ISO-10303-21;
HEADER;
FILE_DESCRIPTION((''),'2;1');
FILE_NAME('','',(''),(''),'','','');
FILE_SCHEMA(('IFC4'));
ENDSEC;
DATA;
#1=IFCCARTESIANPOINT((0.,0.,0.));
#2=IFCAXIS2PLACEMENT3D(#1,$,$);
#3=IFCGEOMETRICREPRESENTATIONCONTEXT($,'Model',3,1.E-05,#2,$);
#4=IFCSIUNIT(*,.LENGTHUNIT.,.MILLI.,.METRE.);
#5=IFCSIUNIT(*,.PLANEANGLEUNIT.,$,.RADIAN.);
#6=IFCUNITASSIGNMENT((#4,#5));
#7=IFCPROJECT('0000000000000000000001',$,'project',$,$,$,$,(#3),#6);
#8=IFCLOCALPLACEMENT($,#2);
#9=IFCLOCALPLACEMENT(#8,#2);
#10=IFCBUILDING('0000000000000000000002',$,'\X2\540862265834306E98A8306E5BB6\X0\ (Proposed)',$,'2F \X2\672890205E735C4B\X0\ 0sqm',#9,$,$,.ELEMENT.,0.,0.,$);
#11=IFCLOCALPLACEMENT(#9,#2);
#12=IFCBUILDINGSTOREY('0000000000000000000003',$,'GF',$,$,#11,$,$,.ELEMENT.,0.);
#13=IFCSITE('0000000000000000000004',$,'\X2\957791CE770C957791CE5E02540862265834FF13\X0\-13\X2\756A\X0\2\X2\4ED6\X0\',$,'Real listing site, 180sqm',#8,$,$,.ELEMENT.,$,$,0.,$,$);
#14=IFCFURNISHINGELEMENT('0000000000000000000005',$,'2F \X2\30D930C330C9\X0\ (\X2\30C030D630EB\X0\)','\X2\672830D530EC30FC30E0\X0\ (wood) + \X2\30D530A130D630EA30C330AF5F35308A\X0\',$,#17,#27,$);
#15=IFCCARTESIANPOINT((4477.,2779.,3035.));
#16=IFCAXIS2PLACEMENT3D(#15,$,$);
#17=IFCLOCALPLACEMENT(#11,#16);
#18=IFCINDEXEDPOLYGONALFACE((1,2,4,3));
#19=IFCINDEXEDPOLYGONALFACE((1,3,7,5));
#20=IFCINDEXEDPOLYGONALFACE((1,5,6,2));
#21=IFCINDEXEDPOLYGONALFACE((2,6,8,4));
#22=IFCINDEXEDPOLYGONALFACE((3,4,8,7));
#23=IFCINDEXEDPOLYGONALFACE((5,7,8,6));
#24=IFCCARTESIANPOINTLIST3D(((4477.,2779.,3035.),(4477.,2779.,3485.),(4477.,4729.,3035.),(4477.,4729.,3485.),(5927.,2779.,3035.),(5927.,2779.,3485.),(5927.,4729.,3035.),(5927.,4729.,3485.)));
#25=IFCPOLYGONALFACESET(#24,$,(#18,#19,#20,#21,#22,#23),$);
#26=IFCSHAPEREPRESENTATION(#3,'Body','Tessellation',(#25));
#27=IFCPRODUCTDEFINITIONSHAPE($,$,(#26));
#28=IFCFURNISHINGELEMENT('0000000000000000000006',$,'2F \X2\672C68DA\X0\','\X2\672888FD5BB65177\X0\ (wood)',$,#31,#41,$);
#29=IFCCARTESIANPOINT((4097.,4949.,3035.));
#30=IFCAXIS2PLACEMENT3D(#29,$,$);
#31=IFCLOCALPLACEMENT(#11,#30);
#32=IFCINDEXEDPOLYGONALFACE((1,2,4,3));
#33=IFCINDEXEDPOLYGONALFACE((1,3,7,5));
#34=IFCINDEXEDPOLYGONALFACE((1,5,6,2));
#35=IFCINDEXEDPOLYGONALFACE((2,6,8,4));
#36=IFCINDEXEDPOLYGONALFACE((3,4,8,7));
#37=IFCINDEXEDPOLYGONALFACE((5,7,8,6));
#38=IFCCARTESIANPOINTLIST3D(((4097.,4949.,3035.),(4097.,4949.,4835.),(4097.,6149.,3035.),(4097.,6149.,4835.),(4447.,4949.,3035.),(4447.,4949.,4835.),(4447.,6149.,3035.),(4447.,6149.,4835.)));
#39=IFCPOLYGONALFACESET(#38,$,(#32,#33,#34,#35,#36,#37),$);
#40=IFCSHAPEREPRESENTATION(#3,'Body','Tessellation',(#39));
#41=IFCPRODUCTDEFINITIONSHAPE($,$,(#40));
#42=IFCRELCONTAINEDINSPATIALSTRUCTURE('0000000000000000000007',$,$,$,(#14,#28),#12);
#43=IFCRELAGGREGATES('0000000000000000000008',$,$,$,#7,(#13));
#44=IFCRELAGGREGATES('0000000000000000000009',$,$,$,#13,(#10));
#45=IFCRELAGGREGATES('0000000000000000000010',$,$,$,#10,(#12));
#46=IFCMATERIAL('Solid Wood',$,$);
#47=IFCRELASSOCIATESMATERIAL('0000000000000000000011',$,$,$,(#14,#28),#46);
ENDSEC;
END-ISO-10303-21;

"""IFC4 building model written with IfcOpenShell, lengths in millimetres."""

from ifc_helpers import new_model, si_unit, frame, frame_2d, origin, place, context, project, spatial, rectangle, extrude, material, element, save


model = new_model("IFC4")

# Units and contexts
model_context = context("Model", 3, precision=1e-05, world=origin())
ifc_project = project(units=[si_unit("LENGTHUNIT", "METRE", prefix="MILLI"), si_unit("PLANEANGLEUNIT", "RADIAN")], contexts=[model_context])

# Site, building, storey
site_placement = place(None, origin())
site = spatial("IfcSite", under=ifc_project, at=site_placement, Name="長野県長野市合戦場３-13番2他", ObjectType="Real listing site, 180sqm", CompositionType="ELEMENT", RefElevation=0.0)
building_placement = place(site_placement, origin())
building = spatial("IfcBuilding", under=site, at=building_placement, Name="合戦場の風の家 (Proposed)", ObjectType="2F 木造平屋 0sqm", CompositionType="ELEMENT", ElevationOfRefHeight=0.0, ElevationOfTerrain=0.0)
storey_placement = place(building_placement, origin())
storey = spatial("IfcBuildingStorey", under=building, at=storey_placement, Name="GF", CompositionType="ELEMENT", Elevation=0.0)

# Shared definitions
ifc_material_1 = material(Name="Solid Wood")

# Furnishing elements
furnishing_1_placement = place(storey_placement, frame((4477.0, 2779.0, 3035.0)))
element("IfcFurnishingElement", 1, at=furnishing_1_placement, inside=storey, material=ifc_material_1, Name="2F ベッド (ダブル)", Description="木フレーム (wood) + ファブリック張り", context=model_context, shape_type="SweptSolid", body=[
    extrude(rectangle(XDim=1450.0, YDim=1950.0, at=frame_2d((725.0, 975.0))), frame((4477.0, 2779.0, 3035.0)), (0.0, 0.0, 1.0), 450.0),
])
furnishing_2_placement = place(storey_placement, frame((4097.0, 4949.0, 3035.0)))
element("IfcFurnishingElement", 2, at=furnishing_2_placement, inside=storey, material=ifc_material_1, Name="2F 本棚", Description="木製家具 (wood)", context=model_context, shape_type="SweptSolid", body=[
    extrude(rectangle(XDim=350.0, YDim=1200.0, at=frame_2d((175.0, 600.0))), frame((4097.0, 4949.0, 3035.0)), (0.0, 0.0, 1.0), 1800.0),
])

save(model, "model.ifc")
